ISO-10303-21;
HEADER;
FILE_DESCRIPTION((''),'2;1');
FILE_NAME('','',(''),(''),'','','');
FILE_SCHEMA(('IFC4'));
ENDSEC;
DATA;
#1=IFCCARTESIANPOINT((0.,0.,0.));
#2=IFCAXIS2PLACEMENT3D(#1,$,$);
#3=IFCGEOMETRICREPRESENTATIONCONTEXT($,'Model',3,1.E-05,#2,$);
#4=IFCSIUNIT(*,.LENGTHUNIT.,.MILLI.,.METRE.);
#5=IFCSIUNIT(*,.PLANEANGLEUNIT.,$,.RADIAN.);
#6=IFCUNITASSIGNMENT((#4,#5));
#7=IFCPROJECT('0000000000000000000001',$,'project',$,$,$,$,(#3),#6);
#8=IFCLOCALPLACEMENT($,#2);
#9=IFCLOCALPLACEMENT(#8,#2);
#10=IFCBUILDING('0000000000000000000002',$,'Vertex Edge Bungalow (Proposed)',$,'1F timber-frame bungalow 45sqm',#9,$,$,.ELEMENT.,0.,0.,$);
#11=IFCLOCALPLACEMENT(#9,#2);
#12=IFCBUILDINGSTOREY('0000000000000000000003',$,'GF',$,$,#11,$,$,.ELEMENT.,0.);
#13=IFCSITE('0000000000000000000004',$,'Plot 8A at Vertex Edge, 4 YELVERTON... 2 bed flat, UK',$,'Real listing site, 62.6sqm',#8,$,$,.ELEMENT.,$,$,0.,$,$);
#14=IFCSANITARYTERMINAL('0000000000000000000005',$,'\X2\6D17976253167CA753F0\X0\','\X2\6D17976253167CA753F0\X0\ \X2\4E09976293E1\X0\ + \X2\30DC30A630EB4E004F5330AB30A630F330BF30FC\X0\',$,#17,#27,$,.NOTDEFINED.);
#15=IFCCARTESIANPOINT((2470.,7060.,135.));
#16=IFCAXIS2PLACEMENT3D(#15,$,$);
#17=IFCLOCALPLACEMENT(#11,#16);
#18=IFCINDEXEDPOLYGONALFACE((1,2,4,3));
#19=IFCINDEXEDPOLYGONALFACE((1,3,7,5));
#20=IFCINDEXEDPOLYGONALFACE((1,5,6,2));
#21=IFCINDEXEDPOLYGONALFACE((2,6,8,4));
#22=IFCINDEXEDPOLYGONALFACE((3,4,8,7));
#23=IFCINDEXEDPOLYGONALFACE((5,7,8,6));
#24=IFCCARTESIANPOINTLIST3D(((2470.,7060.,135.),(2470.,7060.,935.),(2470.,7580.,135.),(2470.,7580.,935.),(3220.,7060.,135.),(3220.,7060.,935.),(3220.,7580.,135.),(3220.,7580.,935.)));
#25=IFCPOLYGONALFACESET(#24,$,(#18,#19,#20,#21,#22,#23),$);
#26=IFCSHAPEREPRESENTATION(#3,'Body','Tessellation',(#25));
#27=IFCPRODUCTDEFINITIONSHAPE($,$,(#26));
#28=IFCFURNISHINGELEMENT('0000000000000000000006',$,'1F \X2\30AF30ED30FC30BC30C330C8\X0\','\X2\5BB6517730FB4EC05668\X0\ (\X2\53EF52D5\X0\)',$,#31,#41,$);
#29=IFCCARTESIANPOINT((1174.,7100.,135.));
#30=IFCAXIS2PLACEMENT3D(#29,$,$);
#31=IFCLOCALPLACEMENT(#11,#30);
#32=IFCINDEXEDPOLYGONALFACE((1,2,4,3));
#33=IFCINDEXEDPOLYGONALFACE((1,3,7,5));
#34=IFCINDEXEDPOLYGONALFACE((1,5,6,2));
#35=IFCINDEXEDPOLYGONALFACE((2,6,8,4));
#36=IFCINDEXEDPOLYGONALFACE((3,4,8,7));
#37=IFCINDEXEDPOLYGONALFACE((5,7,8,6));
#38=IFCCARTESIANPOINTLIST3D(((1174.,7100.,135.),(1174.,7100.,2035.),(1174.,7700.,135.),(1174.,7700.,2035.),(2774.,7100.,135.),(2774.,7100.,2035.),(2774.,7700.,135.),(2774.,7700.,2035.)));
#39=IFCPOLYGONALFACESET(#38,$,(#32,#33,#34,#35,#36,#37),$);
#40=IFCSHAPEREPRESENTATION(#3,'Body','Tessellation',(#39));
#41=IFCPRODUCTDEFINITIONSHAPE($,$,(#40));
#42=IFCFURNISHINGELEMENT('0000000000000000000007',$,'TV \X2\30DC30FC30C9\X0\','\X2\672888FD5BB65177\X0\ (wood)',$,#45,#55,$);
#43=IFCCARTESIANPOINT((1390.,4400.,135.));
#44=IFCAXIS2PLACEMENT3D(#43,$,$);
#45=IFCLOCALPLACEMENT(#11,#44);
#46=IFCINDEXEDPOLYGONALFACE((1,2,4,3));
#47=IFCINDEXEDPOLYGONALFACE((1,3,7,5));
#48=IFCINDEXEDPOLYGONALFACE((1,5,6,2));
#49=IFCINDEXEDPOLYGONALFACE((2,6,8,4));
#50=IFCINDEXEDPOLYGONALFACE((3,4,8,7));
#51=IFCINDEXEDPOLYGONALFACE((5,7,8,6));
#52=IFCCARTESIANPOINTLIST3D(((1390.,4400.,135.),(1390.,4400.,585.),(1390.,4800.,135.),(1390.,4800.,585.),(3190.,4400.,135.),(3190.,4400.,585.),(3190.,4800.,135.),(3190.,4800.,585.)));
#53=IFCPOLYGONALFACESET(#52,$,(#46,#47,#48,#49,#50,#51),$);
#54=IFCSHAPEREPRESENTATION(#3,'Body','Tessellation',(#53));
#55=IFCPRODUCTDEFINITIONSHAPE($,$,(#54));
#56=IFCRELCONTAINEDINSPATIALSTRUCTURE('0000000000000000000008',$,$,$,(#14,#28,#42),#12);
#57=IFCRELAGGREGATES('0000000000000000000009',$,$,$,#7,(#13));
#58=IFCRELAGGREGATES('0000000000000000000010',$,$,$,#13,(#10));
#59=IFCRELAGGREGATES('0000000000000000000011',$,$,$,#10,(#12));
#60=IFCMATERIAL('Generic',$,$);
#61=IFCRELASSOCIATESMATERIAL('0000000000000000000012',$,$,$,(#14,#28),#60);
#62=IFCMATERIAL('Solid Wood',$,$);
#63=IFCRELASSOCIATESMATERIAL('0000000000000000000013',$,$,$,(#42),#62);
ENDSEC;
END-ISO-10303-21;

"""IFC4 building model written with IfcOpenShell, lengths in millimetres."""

from ifc_helpers import new_model, si_unit, frame, frame_2d, origin, place, context, project, spatial, rectangle, extrude, material, element, save


model = new_model("IFC4")

# Units and contexts
model_context = context("Model", 3, precision=1e-05, world=origin())
ifc_project = project(units=[si_unit("LENGTHUNIT", "METRE", prefix="MILLI"), si_unit("PLANEANGLEUNIT", "RADIAN")], contexts=[model_context])

# Site, building, storey
site_placement = place(None, origin())
site = spatial("IfcSite", under=ifc_project, at=site_placement, Name="Plot 8A at Vertex Edge, 4 YELVERTON... 2 bed flat, UK", ObjectType="Real listing site, 62.6sqm", CompositionType="ELEMENT", RefElevation=0.0)
building_placement = place(site_placement, origin())
building = spatial("IfcBuilding", under=site, at=building_placement, Name="Vertex Edge Bungalow (Proposed)", ObjectType="1F timber-frame bungalow 45sqm", CompositionType="ELEMENT", ElevationOfRefHeight=0.0, ElevationOfTerrain=0.0)
storey_placement = place(building_placement, origin())
storey = spatial("IfcBuildingStorey", under=building, at=storey_placement, Name="GF", CompositionType="ELEMENT", Elevation=0.0)

# Shared definitions
ifc_material_1 = material(Name="Solid Wood")

# Shared definitions
ifc_material_2 = material(Name="Generic")

# Sanitary terminal
sanitary_terminal_1_placement = place(storey_placement, frame((2470.0, 7060.0, 135.0)))
element("IfcSanitaryTerminal", 1, at=sanitary_terminal_1_placement, inside=storey, material=ifc_material_2, Name="洗面化粧台", Description="洗面化粧台 三面鏡 + ボウル一体カウンター", PredefinedType="NOTDEFINED", context=model_context, shape_type="SweptSolid", body=[
    extrude(rectangle(XDim=750.0, YDim=520.0, at=frame_2d((375.0, 260.0))), frame((2470.0, 7060.0, 135.0)), (0.0, 0.0, 1.0), 800.0),
])

# Furnishing elements
furnishing_1_placement = place(storey_placement, frame((1174.0, 7100.0, 135.0)))
element("IfcFurnishingElement", 2, at=furnishing_1_placement, inside=storey, material=ifc_material_2, Name="1F クローゼット", Description="家具・什器 (可動)", context=model_context, shape_type="SweptSolid", body=[
    extrude(rectangle(XDim=1600.0, YDim=600.0, at=frame_2d((800.0, 300.0))), frame((1174.0, 7100.0, 135.0)), (0.0, 0.0, 1.0), 1900.0),
])
furnishing_2_placement = place(storey_placement, frame((1390.0, 4400.0, 135.0)))
element("IfcFurnishingElement", 3, at=furnishing_2_placement, inside=storey, material=ifc_material_1, Name="TV ボード", Description="木製家具 (wood)", context=model_context, shape_type="SweptSolid", body=[
    extrude(rectangle(XDim=1800.0, YDim=400.0, at=frame_2d((900.0, 200.0))), frame((1390.0, 4400.0, 135.0)), (0.0, 0.0, 1.0), 450.0),
])

save(model, "model.ifc")
